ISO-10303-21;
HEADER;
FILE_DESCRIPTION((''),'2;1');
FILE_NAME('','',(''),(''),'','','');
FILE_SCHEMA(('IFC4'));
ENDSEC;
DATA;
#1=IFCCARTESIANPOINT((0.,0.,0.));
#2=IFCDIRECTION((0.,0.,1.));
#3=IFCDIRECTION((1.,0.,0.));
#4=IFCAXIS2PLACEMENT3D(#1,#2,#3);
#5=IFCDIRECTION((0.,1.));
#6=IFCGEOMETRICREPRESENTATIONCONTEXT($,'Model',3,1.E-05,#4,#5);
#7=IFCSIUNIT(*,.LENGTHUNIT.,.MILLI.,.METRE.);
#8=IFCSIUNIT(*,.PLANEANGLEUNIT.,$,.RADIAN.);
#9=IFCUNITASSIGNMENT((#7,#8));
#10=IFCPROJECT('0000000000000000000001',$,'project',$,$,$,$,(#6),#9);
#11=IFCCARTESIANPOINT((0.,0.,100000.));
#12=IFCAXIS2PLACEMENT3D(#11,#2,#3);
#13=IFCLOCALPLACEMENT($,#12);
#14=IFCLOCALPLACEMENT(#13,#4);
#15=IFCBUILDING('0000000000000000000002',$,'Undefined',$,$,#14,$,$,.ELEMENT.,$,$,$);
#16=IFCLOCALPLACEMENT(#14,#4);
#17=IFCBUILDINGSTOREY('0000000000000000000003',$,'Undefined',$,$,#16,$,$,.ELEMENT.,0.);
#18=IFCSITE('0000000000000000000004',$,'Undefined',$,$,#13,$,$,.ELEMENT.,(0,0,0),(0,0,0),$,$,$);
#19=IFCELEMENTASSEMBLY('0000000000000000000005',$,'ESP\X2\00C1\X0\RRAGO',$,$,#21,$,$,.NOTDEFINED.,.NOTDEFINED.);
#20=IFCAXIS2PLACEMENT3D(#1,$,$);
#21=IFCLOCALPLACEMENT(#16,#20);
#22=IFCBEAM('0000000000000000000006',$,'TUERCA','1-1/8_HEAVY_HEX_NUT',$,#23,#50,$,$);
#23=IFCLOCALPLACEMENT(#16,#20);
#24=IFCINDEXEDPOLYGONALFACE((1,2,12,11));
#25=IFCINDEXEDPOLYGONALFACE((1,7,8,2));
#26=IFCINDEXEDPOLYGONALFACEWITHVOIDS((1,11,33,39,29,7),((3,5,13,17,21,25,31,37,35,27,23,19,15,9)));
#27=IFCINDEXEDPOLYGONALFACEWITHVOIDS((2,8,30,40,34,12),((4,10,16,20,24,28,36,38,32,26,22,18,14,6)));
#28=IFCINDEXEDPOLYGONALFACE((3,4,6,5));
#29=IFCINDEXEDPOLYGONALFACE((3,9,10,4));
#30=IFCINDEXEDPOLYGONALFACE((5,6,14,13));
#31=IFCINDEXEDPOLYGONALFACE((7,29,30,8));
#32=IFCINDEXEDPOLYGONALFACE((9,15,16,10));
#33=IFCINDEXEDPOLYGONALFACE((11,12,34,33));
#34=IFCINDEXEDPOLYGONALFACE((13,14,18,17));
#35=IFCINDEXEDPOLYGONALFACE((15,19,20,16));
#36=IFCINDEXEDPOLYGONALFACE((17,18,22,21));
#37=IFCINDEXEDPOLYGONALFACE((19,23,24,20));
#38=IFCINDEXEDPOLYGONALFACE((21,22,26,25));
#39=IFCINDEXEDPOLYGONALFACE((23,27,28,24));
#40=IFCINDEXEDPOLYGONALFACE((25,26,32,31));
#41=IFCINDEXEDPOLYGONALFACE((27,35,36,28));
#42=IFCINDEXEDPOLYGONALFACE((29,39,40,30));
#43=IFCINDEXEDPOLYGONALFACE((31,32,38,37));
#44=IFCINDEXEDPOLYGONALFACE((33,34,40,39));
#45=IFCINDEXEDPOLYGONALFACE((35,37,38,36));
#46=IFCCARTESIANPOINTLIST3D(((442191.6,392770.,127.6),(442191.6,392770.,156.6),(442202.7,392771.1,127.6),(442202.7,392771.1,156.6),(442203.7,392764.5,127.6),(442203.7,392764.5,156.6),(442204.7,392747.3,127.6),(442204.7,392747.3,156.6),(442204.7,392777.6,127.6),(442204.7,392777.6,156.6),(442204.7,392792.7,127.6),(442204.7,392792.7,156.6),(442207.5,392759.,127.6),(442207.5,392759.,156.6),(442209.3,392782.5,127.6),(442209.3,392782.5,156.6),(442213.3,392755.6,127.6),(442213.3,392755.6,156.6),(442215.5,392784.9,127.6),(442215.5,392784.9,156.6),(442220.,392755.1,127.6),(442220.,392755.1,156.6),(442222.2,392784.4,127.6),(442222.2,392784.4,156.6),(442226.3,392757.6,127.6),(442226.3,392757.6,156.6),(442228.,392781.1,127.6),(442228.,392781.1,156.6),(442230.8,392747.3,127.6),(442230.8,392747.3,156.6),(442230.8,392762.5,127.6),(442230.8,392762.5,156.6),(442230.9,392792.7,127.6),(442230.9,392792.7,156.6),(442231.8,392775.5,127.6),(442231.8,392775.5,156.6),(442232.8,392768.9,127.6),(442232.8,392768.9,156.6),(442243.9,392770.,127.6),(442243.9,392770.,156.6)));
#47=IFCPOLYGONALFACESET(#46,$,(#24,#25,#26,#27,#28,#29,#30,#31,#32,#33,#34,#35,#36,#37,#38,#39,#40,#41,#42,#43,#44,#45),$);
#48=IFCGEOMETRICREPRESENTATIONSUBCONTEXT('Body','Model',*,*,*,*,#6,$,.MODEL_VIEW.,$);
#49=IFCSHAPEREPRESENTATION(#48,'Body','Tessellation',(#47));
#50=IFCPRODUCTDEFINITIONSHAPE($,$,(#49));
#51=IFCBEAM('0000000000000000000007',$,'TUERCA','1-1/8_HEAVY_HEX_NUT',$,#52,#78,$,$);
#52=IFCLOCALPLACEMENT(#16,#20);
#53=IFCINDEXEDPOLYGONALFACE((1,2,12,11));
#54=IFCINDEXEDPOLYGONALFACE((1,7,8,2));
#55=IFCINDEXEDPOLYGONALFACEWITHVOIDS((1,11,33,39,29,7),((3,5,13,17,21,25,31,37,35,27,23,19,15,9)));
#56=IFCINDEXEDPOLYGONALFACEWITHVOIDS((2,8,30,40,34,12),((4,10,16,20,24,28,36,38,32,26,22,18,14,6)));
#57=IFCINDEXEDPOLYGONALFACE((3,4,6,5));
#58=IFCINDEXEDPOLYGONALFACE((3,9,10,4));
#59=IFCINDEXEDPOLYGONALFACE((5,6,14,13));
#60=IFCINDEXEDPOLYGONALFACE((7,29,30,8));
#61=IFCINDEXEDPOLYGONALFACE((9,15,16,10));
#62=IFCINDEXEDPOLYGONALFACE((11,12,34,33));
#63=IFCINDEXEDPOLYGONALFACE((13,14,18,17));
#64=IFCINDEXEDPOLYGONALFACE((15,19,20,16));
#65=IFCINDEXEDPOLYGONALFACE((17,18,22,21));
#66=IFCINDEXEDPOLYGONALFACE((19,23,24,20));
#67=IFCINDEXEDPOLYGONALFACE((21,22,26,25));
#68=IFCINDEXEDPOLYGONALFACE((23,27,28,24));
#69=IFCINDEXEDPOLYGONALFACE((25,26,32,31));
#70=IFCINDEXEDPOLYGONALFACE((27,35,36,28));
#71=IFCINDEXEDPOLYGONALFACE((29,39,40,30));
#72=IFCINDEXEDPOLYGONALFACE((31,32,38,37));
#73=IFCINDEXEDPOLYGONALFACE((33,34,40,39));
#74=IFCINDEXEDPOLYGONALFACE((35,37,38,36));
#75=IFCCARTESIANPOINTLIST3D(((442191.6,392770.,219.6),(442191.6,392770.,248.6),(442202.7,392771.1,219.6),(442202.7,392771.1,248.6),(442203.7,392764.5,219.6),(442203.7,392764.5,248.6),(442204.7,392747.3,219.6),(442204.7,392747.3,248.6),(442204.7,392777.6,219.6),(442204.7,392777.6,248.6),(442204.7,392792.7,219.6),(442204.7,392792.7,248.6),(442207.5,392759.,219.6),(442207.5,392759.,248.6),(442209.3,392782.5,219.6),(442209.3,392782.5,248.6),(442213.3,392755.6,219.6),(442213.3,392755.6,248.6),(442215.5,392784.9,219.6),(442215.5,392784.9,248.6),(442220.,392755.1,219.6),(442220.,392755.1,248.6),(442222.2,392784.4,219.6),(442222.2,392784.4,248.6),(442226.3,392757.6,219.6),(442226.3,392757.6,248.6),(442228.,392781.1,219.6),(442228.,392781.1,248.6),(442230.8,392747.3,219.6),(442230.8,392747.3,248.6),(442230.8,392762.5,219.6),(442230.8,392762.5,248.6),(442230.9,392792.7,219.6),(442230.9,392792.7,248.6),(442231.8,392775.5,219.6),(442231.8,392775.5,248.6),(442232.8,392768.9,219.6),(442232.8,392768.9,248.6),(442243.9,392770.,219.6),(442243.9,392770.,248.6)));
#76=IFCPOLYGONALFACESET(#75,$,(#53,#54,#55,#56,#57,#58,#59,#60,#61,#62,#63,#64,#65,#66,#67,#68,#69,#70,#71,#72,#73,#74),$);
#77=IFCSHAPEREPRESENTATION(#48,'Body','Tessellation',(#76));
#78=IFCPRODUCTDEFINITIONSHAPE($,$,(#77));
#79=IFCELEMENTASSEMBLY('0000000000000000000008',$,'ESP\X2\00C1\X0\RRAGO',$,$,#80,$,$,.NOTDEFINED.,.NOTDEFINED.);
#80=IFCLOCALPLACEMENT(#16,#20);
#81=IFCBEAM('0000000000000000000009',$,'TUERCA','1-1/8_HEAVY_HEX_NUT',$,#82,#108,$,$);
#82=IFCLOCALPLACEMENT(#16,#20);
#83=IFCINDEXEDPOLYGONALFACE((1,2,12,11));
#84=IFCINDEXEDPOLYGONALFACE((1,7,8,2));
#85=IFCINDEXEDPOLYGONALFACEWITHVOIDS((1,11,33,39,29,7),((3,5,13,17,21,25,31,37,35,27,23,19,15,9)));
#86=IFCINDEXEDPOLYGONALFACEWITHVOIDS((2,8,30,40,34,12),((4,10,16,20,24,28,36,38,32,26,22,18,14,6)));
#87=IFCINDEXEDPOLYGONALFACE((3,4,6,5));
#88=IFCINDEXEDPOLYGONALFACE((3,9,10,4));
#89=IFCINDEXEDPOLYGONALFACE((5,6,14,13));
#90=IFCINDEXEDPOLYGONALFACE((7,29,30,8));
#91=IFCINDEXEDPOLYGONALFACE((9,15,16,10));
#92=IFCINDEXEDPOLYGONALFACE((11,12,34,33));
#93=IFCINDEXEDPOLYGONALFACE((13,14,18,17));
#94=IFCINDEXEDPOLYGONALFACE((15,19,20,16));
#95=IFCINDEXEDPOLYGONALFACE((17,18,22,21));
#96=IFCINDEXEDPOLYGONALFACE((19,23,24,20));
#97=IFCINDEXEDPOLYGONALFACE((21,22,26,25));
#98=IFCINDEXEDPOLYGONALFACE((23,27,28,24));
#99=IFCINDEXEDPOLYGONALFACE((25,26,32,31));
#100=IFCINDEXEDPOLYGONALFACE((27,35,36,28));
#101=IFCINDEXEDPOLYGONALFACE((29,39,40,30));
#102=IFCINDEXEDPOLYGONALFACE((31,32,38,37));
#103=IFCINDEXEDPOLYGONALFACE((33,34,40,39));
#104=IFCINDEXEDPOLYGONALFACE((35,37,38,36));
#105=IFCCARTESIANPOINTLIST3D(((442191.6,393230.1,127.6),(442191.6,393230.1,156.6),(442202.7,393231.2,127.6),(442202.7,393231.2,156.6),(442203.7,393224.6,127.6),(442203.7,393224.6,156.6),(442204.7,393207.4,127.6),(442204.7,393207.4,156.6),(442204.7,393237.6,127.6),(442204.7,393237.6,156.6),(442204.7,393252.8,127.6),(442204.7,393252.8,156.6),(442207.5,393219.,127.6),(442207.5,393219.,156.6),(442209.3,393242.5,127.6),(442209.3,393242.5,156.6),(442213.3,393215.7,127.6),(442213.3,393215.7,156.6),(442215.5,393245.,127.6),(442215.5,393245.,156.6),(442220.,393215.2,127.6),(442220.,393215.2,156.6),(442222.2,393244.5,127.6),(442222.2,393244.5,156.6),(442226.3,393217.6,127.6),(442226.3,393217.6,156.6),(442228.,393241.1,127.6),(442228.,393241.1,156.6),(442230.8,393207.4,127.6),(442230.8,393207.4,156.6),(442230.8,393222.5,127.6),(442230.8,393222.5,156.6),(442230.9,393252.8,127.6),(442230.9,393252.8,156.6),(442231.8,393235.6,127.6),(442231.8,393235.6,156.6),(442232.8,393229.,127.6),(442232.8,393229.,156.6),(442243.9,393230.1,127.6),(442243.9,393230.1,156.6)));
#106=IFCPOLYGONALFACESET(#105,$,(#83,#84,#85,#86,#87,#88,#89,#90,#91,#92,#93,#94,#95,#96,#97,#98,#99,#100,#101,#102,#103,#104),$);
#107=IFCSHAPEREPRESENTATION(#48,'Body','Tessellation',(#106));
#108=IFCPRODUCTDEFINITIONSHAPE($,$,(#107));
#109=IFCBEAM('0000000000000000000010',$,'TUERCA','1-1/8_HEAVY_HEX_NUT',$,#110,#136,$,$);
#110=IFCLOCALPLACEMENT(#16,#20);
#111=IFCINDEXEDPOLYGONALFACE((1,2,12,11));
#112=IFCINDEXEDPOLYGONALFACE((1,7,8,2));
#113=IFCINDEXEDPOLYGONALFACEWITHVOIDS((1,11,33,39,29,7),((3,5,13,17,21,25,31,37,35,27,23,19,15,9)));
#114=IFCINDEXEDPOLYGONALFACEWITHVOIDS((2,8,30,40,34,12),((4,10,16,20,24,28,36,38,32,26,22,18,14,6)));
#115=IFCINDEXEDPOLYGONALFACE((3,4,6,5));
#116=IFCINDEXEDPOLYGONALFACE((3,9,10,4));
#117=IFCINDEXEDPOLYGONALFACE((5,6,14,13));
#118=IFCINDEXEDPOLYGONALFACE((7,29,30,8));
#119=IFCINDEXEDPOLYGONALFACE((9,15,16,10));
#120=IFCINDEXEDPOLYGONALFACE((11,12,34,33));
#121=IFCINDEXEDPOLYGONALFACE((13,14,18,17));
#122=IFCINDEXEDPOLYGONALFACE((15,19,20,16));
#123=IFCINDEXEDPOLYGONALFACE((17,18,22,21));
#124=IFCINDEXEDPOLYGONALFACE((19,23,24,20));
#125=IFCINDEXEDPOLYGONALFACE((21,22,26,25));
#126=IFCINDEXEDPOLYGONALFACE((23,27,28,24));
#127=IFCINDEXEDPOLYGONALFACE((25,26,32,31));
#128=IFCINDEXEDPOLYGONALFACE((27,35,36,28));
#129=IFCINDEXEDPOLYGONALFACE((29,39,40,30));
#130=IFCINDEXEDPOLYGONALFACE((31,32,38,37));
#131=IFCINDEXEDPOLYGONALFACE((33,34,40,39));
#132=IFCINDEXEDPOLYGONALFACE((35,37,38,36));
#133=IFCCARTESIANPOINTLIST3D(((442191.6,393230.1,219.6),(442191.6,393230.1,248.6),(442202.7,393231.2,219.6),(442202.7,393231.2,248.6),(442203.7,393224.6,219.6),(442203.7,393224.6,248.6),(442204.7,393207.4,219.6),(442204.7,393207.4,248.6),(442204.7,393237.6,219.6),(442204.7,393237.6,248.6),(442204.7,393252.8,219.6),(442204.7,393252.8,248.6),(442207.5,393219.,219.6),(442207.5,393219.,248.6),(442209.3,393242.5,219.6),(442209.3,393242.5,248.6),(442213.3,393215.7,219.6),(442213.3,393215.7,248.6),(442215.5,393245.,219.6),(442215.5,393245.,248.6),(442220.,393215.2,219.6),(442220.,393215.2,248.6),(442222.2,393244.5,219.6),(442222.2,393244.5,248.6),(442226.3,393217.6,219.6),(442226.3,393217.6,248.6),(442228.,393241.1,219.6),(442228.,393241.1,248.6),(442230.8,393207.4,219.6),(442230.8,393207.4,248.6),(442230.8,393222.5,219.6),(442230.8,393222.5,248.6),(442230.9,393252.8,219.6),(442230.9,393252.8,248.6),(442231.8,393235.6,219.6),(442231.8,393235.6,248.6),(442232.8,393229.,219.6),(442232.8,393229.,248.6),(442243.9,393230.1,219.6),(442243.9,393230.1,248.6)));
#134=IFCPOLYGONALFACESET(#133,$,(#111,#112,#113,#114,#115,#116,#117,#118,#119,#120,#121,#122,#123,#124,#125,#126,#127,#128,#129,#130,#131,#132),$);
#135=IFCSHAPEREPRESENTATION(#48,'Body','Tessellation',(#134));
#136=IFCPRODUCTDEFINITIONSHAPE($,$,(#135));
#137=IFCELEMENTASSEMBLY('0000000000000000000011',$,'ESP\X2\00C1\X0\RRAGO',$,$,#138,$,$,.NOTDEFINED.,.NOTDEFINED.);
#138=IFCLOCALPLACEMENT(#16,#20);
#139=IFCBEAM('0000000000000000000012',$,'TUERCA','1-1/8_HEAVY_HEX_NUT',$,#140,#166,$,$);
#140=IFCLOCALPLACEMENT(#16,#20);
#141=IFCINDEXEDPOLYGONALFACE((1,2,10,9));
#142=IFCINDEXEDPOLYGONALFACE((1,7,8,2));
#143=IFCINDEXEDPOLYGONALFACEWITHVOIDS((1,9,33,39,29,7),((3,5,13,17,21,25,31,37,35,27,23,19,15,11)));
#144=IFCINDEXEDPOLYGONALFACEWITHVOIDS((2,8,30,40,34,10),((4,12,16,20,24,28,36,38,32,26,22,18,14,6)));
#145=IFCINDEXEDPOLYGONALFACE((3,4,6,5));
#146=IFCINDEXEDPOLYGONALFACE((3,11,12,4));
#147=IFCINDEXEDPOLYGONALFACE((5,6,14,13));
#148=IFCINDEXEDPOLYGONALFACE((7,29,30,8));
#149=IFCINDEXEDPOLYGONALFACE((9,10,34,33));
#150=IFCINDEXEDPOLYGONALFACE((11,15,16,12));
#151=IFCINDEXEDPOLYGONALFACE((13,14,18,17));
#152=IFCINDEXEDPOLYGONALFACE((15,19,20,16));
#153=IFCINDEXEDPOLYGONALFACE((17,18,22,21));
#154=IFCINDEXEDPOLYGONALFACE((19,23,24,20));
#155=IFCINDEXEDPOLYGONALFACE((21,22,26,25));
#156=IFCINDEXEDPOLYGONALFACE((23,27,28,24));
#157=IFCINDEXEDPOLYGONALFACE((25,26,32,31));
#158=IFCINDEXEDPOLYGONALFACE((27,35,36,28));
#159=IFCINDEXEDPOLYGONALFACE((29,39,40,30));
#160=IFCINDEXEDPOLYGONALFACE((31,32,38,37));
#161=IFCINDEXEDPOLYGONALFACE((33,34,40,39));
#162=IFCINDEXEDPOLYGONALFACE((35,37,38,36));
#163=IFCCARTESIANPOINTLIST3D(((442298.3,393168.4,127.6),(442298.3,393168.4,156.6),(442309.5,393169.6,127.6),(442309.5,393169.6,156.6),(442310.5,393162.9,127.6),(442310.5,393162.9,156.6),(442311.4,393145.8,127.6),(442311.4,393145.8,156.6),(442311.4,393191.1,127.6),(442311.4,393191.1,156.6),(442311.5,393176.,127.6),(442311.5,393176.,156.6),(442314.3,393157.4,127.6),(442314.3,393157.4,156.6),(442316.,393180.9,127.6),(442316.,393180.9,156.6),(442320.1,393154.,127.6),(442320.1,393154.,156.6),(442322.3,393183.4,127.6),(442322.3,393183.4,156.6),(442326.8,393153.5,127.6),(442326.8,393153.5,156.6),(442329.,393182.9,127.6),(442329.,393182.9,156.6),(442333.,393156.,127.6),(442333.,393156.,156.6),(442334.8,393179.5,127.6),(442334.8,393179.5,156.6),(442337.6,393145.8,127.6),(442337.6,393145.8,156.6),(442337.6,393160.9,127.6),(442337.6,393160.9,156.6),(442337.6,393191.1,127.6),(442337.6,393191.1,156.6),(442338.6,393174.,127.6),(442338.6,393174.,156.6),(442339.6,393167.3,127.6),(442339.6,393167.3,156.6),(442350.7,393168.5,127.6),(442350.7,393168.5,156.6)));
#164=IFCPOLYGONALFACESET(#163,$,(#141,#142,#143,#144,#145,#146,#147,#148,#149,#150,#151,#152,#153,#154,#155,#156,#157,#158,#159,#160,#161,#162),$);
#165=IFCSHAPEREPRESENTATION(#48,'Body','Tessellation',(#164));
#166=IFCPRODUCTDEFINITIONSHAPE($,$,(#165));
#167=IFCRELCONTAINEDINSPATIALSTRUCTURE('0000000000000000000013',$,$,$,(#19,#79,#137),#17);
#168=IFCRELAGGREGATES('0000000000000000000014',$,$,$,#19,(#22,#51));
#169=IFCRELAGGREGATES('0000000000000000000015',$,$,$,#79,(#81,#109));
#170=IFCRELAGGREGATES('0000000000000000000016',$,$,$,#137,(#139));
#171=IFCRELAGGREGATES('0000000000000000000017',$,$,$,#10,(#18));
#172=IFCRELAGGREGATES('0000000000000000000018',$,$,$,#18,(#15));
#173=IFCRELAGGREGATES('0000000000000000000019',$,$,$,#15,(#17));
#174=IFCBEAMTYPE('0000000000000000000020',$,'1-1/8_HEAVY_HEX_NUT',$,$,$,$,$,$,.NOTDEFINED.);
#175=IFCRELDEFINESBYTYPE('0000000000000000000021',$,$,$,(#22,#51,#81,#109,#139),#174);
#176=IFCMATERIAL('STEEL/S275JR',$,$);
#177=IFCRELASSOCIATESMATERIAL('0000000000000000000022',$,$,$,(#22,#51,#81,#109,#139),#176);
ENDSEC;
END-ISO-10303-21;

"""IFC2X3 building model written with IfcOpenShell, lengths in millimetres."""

from ifc_helpers import new_model, si_unit, direction, frame, origin_with_axes, place, context, subcontext, project, spatial, polyline, outline, extrude, material, type_object, element, aggregate, save


model = new_model("IFC2X3")

# Units and contexts
model_context = context("Model", 3, precision=1e-05, world=origin_with_axes(), true_north=direction((0.0, 1.0)))
body_context = subcontext(model_context, "Body", "Model", "MODEL_VIEW")
ifc_project = project(units=[si_unit("LENGTHUNIT", "METRE", prefix="MILLI"), si_unit("PLANEANGLEUNIT", "RADIAN")], contexts=[model_context])

# Site, building, storey
site_placement = place(None, frame((0.0, 0.0, 100000.0), z_axis=(0.0, 0.0, 1.0), x_axis=(1.0, 0.0, 0.0)))
site = spatial("IfcSite", under=ifc_project, at=site_placement, Name="Undefined", CompositionType="ELEMENT", RefLatitude=(0, 0, 0), RefLongitude=(0, 0, 0))
building_placement = place(site_placement, origin_with_axes())
building = spatial("IfcBuilding", under=site, at=building_placement, Name="Undefined", CompositionType="ELEMENT")
storey_placement = place(building_placement, origin_with_axes())
storey = spatial("IfcBuildingStorey", under=building, at=storey_placement, Name="Undefined", CompositionType="ELEMENT", Elevation=0.0)

# Element assemblies, beams
assembly_1_placement = place(storey_placement, origin_with_axes())
assembly_1 = element("IfcElementAssembly", 1, at=assembly_1_placement, inside=storey, Name="ESPÁRRAGO", AssemblyPlace="NOTDEFINED", PredefinedType="NOTDEFINED")
ifc_material = material(Name="STEEL/S275JR")
beam_type_1 = type_object("IfcBeamType", Name="1-1/8_HEAVY_HEX_NUT", PredefinedType="NOTDEFINED")
beam_1_placement = place(assembly_1_placement, frame((442217.8, 392770.0, 156.6), z_axis=(0.866025, -0.5, 0.0), x_axis=(0.0, 0.0, -1.0)))
beam_1 = element("IfcBeam", 2, at=beam_1_placement, type_object=beam_type_1, material=ifc_material, Name="TUERCA", Description="1-1/8_HEAVY_HEX_NUT", context=body_context, shape_type="SweptSolid", body=[
    extrude(outline(polyline([(-13.1, -22.7), (-26.2, 0.0), (-13.1, 22.7), (13.1, 22.7), (26.2, 0.0), (13.1, -22.7), (-13.1, -22.7)]), holes=[polyline([(6.5, 13.6), (0.0, 15.1), (-6.5, 13.6), (-11.8, 9.4), (-14.7, 3.4), (-14.7, -3.4), (-11.8, -9.4), (-6.5, -13.6), (0.0, -15.1), (6.5, -13.6), (11.8, -9.4), (14.7, -3.4), (14.7, 3.4), (11.8, 9.4), (6.5, 13.6)])]), frame((29.0, 0.0, 0.0), z_axis=(-1.0, 0.0, 0.0), x_axis=(0.0, -1.0, 0.0)), (0.0, 0.0, 1.0), 29.0),
])
beam_2_placement = place(assembly_1_placement, frame((442217.8, 392770.0, 248.6), z_axis=(0.866025, -0.5, 0.0), x_axis=(0.0, 0.0, -1.0)))
beam_2 = element("IfcBeam", 3, at=beam_2_placement, type_object=beam_type_1, material=ifc_material, Name="TUERCA", Description="1-1/8_HEAVY_HEX_NUT", context=body_context, shape_type="SweptSolid", body=[
    extrude(outline(polyline([(-13.1, -22.7), (-26.2, 0.0), (-13.1, 22.7), (13.1, 22.7), (26.2, 0.0), (13.1, -22.7), (-13.1, -22.7)]), holes=[polyline([(6.5, 13.6), (0.0, 15.1), (-6.5, 13.6), (-11.8, 9.4), (-14.7, 3.4), (-14.7, -3.4), (-11.8, -9.4), (-6.5, -13.6), (0.0, -15.1), (6.5, -13.6), (11.8, -9.4), (14.7, -3.4), (14.7, 3.4), (11.8, 9.4), (6.5, 13.6)])]), frame((29.0, 0.0, 0.0), z_axis=(-1.0, 0.0, 0.0), x_axis=(0.0, -1.0, 0.0)), (0.0, 0.0, 1.0), 29.0),
])
assembly_2_placement = place(storey_placement, origin_with_axes())
assembly_2 = element("IfcElementAssembly", 4, at=assembly_2_placement, inside=storey, Name="ESPÁRRAGO", AssemblyPlace="NOTDEFINED", PredefinedType="NOTDEFINED")
beam_3_placement = place(assembly_2_placement, frame((442217.8, 393230.1, 156.6), z_axis=(0.866025, -0.5, 0.0), x_axis=(0.0, 0.0, -1.0)))
beam_3 = element("IfcBeam", 5, at=beam_3_placement, type_object=beam_type_1, material=ifc_material, Name="TUERCA", Description="1-1/8_HEAVY_HEX_NUT", context=body_context, shape_type="SweptSolid", body=[
    extrude(outline(polyline([(-13.1, -22.7), (-26.2, 0.0), (-13.1, 22.7), (13.1, 22.7), (26.2, 0.0), (13.1, -22.7), (-13.1, -22.7)]), holes=[polyline([(6.5, 13.6), (0.0, 15.1), (-6.5, 13.6), (-11.8, 9.4), (-14.7, 3.4), (-14.7, -3.4), (-11.8, -9.4), (-6.5, -13.6), (0.0, -15.1), (6.5, -13.6), (11.8, -9.4), (14.7, -3.4), (14.7, 3.4), (11.8, 9.4), (6.5, 13.6)])]), frame((29.0, 0.0, 0.0), z_axis=(-1.0, 0.0, 0.0), x_axis=(0.0, -1.0, 0.0)), (0.0, 0.0, 1.0), 29.0),
])
beam_4_placement = place(assembly_2_placement, frame((442217.8, 393230.1, 248.6), z_axis=(0.866025, -0.5, 0.0), x_axis=(0.0, 0.0, -1.0)))
beam_4 = element("IfcBeam", 6, at=beam_4_placement, type_object=beam_type_1, material=ifc_material, Name="TUERCA", Description="1-1/8_HEAVY_HEX_NUT", context=body_context, shape_type="SweptSolid", body=[
    extrude(outline(polyline([(-13.1, -22.7), (-26.2, 0.0), (-13.1, 22.7), (13.1, 22.7), (26.2, 0.0), (13.1, -22.7), (-13.1, -22.7)]), holes=[polyline([(6.5, 13.6), (0.0, 15.1), (-6.5, 13.6), (-11.8, 9.4), (-14.7, 3.4), (-14.7, -3.4), (-11.8, -9.4), (-6.5, -13.6), (0.0, -15.1), (6.5, -13.6), (11.8, -9.4), (14.7, -3.4), (14.7, 3.4), (11.8, 9.4), (6.5, 13.6)])]), frame((29.0, 0.0, 0.0), z_axis=(-1.0, 0.0, 0.0), x_axis=(0.0, -1.0, 0.0)), (0.0, 0.0, 1.0), 29.0),
])
assembly_3_placement = place(storey_placement, origin_with_axes())
assembly_3 = element("IfcElementAssembly", 7, at=assembly_3_placement, inside=storey, Name="ESPÁRRAGO", AssemblyPlace="NOTDEFINED", PredefinedType="NOTDEFINED")
beam_5_placement = place(assembly_3_placement, frame((442324.5, 393168.4, 156.6), z_axis=(0.866025, -0.5, 0.0), x_axis=(0.0, 0.0, -1.0)))
beam_5 = element("IfcBeam", 8, at=beam_5_placement, type_object=beam_type_1, material=ifc_material, Name="TUERCA", Description="1-1/8_HEAVY_HEX_NUT", context=body_context, shape_type="SweptSolid", body=[
    extrude(outline(polyline([(-13.1, -22.7), (-26.2, 0.0), (-13.1, 22.7), (13.1, 22.7), (26.2, 0.0), (13.1, -22.7), (-13.1, -22.7)]), holes=[polyline([(6.5, 13.6), (0.0, 15.1), (-6.5, 13.6), (-11.8, 9.4), (-14.7, 3.4), (-14.7, -3.4), (-11.8, -9.4), (-6.5, -13.6), (0.0, -15.1), (6.5, -13.6), (11.8, -9.4), (14.7, -3.4), (14.7, 3.4), (11.8, 9.4), (6.5, 13.6)])]), frame((29.0, 0.0, 0.0), z_axis=(-1.0, 0.0, 0.0), x_axis=(0.0, -1.0, 0.0)), (0.0, 0.0, 1.0), 29.0),
])

aggregate(assembly_1, [beam_1, beam_2])
aggregate(assembly_2, [beam_3, beam_4])
aggregate(assembly_3, [beam_5])

save(model, "model.ifc")
